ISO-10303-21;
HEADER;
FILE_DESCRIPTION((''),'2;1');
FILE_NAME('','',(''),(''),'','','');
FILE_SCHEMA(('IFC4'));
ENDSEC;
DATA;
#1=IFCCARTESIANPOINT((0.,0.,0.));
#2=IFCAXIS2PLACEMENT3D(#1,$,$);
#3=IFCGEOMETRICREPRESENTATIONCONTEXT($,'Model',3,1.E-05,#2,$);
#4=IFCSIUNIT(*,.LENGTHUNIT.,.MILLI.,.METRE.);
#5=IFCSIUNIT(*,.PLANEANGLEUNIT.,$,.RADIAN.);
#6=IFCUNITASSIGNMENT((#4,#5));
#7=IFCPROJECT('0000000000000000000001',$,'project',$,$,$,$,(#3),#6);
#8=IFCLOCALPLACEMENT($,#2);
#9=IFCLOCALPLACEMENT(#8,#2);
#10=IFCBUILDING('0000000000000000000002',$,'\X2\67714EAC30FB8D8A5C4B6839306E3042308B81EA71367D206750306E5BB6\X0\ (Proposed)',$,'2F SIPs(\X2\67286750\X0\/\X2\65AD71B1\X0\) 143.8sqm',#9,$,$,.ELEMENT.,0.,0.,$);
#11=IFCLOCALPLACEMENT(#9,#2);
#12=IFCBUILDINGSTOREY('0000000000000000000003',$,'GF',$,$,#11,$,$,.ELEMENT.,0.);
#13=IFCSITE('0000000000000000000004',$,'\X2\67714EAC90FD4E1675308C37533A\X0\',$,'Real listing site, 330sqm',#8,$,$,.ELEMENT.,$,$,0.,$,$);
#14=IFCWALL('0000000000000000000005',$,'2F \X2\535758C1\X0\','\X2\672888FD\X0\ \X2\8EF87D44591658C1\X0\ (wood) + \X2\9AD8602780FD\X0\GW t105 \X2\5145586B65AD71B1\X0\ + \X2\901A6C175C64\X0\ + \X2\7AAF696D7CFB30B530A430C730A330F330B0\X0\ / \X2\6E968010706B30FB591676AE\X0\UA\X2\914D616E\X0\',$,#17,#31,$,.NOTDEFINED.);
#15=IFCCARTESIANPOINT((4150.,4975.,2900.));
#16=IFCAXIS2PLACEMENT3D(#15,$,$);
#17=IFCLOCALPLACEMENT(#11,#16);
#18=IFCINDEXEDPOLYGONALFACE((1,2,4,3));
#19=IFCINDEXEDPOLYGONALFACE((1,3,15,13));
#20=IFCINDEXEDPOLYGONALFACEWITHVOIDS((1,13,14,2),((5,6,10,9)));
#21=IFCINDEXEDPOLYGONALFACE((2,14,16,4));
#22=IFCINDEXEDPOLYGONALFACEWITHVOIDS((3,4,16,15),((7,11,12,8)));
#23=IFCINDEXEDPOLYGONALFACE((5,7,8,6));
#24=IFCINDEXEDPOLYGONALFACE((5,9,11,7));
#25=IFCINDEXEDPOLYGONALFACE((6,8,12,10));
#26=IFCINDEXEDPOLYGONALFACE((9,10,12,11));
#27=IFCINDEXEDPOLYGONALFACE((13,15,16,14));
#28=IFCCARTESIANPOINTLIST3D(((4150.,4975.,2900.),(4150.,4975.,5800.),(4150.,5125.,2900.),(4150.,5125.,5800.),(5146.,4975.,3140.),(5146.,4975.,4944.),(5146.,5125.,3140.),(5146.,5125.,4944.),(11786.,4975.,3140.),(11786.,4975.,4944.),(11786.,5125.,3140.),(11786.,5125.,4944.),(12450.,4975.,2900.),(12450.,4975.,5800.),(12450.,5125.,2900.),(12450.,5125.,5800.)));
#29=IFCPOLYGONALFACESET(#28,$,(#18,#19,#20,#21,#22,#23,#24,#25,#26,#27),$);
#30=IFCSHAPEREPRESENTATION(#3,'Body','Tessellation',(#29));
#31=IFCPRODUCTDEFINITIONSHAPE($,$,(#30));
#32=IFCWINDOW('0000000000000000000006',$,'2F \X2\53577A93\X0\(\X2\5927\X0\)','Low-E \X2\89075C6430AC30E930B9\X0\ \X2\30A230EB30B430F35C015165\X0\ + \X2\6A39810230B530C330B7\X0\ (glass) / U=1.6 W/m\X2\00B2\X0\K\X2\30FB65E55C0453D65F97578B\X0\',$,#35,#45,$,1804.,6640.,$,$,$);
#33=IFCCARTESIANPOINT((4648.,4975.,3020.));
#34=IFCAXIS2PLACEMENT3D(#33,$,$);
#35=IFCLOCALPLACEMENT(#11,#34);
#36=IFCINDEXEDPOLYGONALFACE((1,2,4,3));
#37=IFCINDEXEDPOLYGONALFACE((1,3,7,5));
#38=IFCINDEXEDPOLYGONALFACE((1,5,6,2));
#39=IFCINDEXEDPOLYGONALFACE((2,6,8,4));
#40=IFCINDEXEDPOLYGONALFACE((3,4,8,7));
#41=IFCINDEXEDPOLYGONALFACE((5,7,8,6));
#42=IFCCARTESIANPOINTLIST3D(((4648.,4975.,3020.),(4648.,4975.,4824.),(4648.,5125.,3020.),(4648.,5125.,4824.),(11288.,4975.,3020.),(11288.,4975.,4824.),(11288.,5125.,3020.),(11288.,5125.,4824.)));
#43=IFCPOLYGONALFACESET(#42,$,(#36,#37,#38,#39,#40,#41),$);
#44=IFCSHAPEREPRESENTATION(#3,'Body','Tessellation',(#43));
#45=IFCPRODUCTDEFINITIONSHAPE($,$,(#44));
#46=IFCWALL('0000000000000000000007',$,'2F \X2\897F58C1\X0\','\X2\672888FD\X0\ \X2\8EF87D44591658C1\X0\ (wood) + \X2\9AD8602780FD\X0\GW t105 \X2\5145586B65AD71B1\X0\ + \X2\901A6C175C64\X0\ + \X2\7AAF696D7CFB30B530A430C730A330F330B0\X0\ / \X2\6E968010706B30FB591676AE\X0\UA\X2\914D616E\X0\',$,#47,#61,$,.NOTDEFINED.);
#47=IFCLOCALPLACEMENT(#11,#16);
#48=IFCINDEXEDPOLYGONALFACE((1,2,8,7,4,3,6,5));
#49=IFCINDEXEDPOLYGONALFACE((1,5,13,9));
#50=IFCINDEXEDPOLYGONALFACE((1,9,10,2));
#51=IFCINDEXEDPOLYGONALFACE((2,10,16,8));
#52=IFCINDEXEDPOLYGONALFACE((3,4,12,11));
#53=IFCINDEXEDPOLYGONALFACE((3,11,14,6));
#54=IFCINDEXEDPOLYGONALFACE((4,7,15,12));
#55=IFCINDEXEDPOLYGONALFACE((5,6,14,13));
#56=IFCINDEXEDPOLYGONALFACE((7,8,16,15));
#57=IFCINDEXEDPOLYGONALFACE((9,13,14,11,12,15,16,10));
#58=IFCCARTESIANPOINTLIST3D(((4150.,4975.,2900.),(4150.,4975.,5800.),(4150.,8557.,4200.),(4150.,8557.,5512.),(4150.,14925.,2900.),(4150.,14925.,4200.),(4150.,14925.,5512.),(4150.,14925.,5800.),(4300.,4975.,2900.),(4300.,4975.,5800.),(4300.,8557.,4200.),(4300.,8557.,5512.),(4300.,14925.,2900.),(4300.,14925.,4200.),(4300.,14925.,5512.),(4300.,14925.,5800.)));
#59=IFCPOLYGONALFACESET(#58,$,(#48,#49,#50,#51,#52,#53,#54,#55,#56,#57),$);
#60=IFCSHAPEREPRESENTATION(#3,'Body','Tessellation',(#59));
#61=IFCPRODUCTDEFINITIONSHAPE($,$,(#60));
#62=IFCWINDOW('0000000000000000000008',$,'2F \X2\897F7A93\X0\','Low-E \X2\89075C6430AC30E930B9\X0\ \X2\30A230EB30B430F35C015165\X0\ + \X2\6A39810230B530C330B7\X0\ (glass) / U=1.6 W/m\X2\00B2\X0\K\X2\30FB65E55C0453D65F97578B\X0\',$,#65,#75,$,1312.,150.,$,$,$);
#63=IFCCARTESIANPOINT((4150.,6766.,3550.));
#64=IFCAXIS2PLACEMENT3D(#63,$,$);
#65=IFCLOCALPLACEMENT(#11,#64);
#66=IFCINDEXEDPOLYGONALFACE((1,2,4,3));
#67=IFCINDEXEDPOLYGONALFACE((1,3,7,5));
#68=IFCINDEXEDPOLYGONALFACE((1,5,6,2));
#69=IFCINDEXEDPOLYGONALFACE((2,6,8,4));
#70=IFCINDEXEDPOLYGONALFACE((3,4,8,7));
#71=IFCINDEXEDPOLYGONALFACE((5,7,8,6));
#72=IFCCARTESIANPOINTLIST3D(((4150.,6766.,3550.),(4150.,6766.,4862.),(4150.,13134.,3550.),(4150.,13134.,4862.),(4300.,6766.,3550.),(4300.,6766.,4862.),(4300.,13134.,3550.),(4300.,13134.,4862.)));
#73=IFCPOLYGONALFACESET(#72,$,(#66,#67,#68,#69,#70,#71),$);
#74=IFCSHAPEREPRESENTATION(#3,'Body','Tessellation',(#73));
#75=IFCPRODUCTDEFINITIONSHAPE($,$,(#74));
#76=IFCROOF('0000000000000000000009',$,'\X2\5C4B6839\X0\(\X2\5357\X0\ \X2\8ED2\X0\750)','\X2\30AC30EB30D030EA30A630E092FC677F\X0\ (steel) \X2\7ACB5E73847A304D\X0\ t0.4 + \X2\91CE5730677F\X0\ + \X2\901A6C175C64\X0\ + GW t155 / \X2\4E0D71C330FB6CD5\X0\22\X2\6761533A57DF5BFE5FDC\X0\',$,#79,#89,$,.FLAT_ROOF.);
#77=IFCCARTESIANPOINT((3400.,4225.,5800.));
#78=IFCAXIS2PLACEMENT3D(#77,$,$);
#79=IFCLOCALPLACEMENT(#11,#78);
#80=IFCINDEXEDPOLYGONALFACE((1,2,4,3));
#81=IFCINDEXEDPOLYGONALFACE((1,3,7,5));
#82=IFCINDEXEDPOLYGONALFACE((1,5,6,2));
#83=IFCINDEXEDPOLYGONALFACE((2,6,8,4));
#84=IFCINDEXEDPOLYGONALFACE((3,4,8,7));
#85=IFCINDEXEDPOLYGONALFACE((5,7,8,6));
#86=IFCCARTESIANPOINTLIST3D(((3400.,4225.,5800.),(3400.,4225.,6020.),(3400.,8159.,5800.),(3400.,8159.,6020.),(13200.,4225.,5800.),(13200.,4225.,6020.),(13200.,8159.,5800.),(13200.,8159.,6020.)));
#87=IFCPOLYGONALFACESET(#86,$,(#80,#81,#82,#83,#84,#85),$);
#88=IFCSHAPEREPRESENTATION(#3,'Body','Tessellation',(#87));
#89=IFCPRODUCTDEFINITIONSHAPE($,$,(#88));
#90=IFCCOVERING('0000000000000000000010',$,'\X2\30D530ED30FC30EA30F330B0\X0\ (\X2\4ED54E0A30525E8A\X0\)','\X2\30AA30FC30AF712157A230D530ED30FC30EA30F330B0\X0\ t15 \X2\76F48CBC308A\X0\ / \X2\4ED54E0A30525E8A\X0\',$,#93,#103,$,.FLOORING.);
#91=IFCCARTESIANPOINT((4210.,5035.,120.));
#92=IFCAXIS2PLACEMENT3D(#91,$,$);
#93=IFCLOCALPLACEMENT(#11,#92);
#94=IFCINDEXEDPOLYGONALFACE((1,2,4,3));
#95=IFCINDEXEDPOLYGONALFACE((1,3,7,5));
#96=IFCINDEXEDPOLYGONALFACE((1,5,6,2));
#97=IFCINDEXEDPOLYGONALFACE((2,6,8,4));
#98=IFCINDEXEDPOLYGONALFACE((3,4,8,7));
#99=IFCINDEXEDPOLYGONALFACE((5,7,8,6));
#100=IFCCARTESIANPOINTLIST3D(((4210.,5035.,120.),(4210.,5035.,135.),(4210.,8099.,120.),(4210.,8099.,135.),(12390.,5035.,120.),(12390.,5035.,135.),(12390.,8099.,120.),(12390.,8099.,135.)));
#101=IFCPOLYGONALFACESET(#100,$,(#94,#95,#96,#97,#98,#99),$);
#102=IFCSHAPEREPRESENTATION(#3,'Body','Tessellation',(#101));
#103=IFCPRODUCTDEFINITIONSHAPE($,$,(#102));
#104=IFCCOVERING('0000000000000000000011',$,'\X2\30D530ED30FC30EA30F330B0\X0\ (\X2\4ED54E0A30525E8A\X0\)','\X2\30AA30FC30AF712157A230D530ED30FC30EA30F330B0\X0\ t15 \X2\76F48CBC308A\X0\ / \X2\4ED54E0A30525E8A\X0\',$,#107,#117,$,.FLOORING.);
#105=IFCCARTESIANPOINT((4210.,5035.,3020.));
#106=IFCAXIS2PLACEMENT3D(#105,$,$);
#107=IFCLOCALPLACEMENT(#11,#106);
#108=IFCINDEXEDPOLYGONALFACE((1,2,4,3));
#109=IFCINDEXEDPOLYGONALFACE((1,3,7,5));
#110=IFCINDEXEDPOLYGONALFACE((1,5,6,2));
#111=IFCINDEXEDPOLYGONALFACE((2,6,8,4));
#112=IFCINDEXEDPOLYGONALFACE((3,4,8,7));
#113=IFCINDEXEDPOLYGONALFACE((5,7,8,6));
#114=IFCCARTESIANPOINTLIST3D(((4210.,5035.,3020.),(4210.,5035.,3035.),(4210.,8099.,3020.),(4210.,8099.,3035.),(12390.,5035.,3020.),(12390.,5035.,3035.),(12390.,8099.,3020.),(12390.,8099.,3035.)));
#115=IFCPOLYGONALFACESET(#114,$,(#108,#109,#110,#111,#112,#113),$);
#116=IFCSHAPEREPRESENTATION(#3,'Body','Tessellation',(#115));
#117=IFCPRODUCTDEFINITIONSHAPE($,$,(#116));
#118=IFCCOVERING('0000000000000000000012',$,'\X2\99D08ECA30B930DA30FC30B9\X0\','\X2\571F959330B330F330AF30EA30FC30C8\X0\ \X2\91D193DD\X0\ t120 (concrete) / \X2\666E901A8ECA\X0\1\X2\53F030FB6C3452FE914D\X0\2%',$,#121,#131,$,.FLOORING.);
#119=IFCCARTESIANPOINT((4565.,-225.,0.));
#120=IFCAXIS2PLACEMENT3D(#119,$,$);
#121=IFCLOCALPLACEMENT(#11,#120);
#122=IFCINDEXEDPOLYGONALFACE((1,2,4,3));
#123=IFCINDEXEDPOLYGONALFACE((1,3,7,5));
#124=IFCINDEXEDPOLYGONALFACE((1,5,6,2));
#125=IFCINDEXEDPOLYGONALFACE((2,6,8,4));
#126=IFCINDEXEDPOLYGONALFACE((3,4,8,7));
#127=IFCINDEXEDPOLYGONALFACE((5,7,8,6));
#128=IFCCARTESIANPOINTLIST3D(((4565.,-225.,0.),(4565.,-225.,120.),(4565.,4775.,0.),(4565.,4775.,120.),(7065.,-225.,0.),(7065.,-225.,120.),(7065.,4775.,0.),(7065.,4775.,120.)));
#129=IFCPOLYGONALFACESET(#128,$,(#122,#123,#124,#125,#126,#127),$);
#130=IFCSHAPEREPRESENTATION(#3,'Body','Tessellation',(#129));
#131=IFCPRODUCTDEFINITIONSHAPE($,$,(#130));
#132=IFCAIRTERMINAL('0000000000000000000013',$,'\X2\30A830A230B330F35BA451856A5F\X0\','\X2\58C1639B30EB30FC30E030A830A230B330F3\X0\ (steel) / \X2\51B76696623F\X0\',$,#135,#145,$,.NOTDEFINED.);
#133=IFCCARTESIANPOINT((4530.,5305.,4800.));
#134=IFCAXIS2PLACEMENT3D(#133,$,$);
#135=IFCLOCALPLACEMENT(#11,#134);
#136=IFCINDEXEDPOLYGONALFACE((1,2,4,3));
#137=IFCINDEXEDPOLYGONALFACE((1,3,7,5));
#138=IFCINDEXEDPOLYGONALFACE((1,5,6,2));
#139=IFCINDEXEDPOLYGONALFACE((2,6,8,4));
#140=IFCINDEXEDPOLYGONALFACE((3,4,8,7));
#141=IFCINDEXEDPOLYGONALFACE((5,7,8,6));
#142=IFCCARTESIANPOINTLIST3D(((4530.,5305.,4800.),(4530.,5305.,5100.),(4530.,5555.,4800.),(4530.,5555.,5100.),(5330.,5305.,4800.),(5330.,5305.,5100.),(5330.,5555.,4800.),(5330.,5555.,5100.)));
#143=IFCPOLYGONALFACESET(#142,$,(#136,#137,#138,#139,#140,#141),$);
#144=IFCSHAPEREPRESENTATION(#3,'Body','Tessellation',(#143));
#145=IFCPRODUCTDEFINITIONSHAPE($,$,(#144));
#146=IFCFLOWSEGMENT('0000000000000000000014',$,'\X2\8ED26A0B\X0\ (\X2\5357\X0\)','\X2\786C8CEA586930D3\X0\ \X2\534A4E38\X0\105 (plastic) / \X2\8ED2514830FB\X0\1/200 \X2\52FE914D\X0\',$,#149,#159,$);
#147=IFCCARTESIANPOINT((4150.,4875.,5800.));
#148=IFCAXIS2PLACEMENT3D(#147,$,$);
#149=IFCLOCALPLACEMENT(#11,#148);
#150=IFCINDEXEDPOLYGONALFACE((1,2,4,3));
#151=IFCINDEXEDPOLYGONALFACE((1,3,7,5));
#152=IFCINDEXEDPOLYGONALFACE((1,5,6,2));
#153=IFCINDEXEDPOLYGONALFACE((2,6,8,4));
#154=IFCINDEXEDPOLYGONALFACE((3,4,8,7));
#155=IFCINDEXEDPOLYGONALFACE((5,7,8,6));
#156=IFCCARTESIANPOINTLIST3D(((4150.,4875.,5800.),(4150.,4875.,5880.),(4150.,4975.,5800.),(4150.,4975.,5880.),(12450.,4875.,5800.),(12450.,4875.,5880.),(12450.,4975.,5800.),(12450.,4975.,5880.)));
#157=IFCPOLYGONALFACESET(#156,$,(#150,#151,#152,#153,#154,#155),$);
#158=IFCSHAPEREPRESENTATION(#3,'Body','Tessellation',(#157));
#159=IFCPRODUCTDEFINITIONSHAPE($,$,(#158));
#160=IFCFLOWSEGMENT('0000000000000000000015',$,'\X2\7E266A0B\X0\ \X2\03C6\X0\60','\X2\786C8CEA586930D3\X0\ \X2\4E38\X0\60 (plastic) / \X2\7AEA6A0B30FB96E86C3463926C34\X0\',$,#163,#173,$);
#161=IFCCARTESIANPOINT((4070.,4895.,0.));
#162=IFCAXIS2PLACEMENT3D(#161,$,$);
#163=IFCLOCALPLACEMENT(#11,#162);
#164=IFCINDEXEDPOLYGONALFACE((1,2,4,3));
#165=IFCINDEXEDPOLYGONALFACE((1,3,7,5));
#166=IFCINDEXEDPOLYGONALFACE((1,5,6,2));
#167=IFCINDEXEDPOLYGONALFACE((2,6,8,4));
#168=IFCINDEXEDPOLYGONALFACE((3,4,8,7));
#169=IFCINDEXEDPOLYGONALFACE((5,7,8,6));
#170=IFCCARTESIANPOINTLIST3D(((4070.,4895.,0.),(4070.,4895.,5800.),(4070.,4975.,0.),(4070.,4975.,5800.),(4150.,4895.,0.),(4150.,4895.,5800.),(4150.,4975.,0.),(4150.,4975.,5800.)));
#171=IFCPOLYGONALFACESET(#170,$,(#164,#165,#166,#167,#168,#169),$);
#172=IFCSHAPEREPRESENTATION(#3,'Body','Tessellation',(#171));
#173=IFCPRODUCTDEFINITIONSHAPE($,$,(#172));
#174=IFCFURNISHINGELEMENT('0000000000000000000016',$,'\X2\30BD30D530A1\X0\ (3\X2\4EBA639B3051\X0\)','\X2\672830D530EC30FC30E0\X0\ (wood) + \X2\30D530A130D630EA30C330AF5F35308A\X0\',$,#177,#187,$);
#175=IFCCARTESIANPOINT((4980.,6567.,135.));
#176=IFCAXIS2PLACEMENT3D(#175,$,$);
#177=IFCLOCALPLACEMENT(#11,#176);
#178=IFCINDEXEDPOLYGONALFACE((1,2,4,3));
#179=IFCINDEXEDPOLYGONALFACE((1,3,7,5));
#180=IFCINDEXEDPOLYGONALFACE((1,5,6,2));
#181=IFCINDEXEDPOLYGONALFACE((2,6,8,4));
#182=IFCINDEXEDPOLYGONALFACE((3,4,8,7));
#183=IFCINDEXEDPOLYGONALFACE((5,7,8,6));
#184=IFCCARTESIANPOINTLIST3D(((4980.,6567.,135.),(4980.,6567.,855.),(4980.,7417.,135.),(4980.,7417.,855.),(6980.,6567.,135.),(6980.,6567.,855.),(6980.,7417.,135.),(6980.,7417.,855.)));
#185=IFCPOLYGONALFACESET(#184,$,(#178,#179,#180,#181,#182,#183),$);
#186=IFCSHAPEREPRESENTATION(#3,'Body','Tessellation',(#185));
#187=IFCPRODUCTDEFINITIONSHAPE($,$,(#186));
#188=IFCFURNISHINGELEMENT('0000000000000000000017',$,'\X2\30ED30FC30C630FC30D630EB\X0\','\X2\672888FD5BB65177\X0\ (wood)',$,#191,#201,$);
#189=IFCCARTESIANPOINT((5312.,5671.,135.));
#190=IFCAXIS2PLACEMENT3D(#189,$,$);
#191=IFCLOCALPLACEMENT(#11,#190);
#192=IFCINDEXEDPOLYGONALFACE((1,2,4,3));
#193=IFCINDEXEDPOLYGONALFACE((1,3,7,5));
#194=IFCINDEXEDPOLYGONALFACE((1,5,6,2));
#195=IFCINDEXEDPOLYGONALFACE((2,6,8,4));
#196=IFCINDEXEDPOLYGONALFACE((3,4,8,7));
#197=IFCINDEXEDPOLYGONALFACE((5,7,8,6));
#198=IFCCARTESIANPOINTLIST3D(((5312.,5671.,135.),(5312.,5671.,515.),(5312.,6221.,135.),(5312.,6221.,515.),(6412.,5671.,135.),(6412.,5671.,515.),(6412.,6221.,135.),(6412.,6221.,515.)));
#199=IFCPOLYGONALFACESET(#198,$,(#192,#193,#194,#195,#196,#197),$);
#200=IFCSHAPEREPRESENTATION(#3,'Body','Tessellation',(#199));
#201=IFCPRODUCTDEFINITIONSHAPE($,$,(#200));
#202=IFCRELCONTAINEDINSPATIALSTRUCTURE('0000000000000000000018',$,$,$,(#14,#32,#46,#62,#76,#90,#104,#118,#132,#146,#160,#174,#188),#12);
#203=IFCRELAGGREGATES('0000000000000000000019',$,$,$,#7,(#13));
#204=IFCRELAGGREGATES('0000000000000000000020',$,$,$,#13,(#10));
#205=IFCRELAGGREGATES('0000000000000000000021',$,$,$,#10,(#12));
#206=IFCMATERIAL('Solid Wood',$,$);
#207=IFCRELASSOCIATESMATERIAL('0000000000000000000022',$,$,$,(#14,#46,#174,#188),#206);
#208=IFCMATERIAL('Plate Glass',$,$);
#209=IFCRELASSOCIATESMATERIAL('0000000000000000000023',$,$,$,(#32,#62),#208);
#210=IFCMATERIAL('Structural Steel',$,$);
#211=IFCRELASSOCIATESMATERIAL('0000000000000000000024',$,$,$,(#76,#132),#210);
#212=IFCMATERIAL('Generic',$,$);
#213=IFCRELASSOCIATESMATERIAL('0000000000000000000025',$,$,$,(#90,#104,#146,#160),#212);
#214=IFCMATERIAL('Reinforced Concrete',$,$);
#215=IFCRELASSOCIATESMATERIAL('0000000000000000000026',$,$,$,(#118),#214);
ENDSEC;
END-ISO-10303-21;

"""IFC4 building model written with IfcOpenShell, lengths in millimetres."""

from ifc_helpers import new_model, si_unit, frame, frame_2d, origin, place, context, project, spatial, rectangle, extrude, material, element, fill, save


model = new_model("IFC4")

# Units and contexts
model_context = context("Model", 3, precision=1e-05, world=origin())
ifc_project = project(units=[si_unit("LENGTHUNIT", "METRE", prefix="MILLI"), si_unit("PLANEANGLEUNIT", "RADIAN")], contexts=[model_context])

# Site, building, storey
site_placement = place(None, origin())
site = spatial("IfcSite", under=ifc_project, at=site_placement, Name="東京都世田谷区", ObjectType="Real listing site, 330sqm", CompositionType="ELEMENT", RefElevation=0.0)
building_placement = place(site_placement, origin())
building = spatial("IfcBuilding", under=site, at=building_placement, Name="東京・越屋根のある自然素材の家 (Proposed)", ObjectType="2F SIPs(木材/断熱) 143.8sqm", CompositionType="ELEMENT", ElevationOfRefHeight=0.0, ElevationOfTerrain=0.0)
storey_placement = place(building_placement, origin())
storey = spatial("IfcBuildingStorey", under=building, at=storey_placement, Name="GF", CompositionType="ELEMENT", Elevation=0.0)

# Shared definitions
ifc_material_1 = material(Name="Solid Wood")

# Shared definitions
ifc_material_2 = material(Name="Reinforced Concrete")

# Shared definitions
ifc_material_3 = material(Name="Plate Glass")

# Walls, openings, windows
wall_1_placement = place(storey_placement, frame((4150.0, 4975.0, 2900.0)))
wall_1 = element("IfcWall", 1, at=wall_1_placement, inside=storey, material=ifc_material_1, Name="2F 南壁", Description="木製 軸組外壁 (wood) + 高性能GW t105 充填断熱 + 通気層 + 窯業系サイディング / 準耐火・外皮UA配慮", PredefinedType="NOTDEFINED", context=model_context, shape_type="SweptSolid", body=[
    extrude(rectangle(XDim=8300.0, YDim=150.0, at=frame_2d((4150.0, 75.0))), frame((4150.0, 4975.0, 2900.0)), (0.0, 0.0, 1.0), 2900.0),
])
opening_1_placement = place(storey_placement, frame((4648.0, 4975.0, 3020.0)))
opening_1 = element("IfcOpeningElement", 2, at=opening_1_placement, cuts=wall_1, PredefinedType="NOTDEFINED", context=model_context, shape_type="SweptSolid", body=[
    extrude(rectangle(XDim=6640.0, YDim=150.0, at=frame_2d((3320.0, 75.0))), frame((4648.0, 4975.0, 3020.0)), (0.0, 0.0, 1.0), 1804.0),
])
window_1_placement = place(storey_placement, frame((4648.0, 4975.0, 3020.0)))
window_1 = element("IfcWindow", 3, at=window_1_placement, inside=storey, material=ifc_material_3, Name="2F 南窓(大)", Description="Low-E 複層ガラス アルゴン封入 + 樹脂サッシ (glass) / U=1.6 W/m²K・日射取得型", OverallHeight=1804.0, OverallWidth=6640.0, context=model_context, shape_type="SweptSolid", body=[
    extrude(rectangle(XDim=6640.0, YDim=150.0, at=frame_2d((3320.0, 75.0))), frame((4648.0, 4975.0, 3020.0)), (0.0, 0.0, 1.0), 1804.0),
])
fill(opening_1, window_1)
wall_2_placement = place(storey_placement, frame((4150.0, 4975.0, 2900.0)))
wall_2 = element("IfcWall", 4, at=wall_2_placement, inside=storey, material=ifc_material_1, Name="2F 西壁", Description="木製 軸組外壁 (wood) + 高性能GW t105 充填断熱 + 通気層 + 窯業系サイディング / 準耐火・外皮UA配慮", PredefinedType="NOTDEFINED", context=model_context, shape_type="SweptSolid", body=[
    extrude(rectangle(XDim=150.0, YDim=9950.0, at=frame_2d((75.0, 4975.0))), frame((4150.0, 4975.0, 2900.0)), (0.0, 0.0, 1.0), 2900.0),
])
opening_2_placement = place(storey_placement, frame((4150.0, 6766.0, 3550.0)))
opening_2 = element("IfcOpeningElement", 5, at=opening_2_placement, cuts=wall_2, PredefinedType="NOTDEFINED", context=model_context, shape_type="SweptSolid", body=[
    extrude(rectangle(XDim=150.0, YDim=6368.0, at=frame_2d((75.0, 3184.0))), frame((4150.0, 6766.0, 3550.0)), (0.0, 0.0, 1.0), 1312.0),
])
window_2_placement = place(storey_placement, frame((4150.0, 6766.0, 3550.0)))
window_2 = element("IfcWindow", 6, at=window_2_placement, inside=storey, material=ifc_material_3, Name="2F 西窓", Description="Low-E 複層ガラス アルゴン封入 + 樹脂サッシ (glass) / U=1.6 W/m²K・日射取得型", OverallHeight=1312.0, OverallWidth=150.0, context=model_context, shape_type="SweptSolid", body=[
    extrude(rectangle(XDim=150.0, YDim=6368.0, at=frame_2d((75.0, 3184.0))), frame((4150.0, 6766.0, 3550.0)), (0.0, 0.0, 1.0), 1312.0),
])
fill(opening_2, window_2)

# Roof
ifc_material_4 = material(Name="Structural Steel")
for number, where, name in (
    (7, (3400.0, 4225.0, 5800.0), "屋根(南 軒750)"),
):
    element("IfcRoof", number, at=place(storey_placement, frame(where)), inside=storey, material=ifc_material_4, Name=name, Description="ガルバリウム鋼板 (steel) 立平葺き t0.4 + 野地板 + 通気層 + GW t155 / 不燃・法22条区域対応", PredefinedType="FLAT_ROOF", context=model_context, shape_type="SweptSolid", body=[
        extrude(rectangle(XDim=9800.0, YDim=3934.0, at=frame_2d((4900.0, 1967.0))), frame((3400.0, 4225.0, 5800.0)), (0.0, 0.0, 1.0), 220.0),
    ])

# Coverings
ifc_material_5 = material(Name="Generic")
covering_1_placement = place(storey_placement, frame((4210.0, 5035.0, 120.0)))
element("IfcCovering", 8, at=covering_1_placement, inside=storey, material=ifc_material_5, Name="フローリング (仕上げ床)", Description="オーク無垢フローリング t15 直貼り / 仕上げ床", PredefinedType="FLOORING", context=model_context, shape_type="SweptSolid", body=[
    extrude(rectangle(XDim=8180.0, YDim=3064.0, at=frame_2d((4090.0, 1532.0))), frame((4210.0, 5035.0, 120.0)), (0.0, 0.0, 1.0), 15.0),
])
covering_2_placement = place(storey_placement, frame((4210.0, 5035.0, 3020.0)))
element("IfcCovering", 9, at=covering_2_placement, inside=storey, material=ifc_material_5, Name="フローリング (仕上げ床)", Description="オーク無垢フローリング t15 直貼り / 仕上げ床", PredefinedType="FLOORING", context=model_context, shape_type="SweptSolid", body=[
    extrude(rectangle(XDim=8180.0, YDim=3064.0, at=frame_2d((4090.0, 1532.0))), frame((4210.0, 5035.0, 3020.0)), (0.0, 0.0, 1.0), 15.0),
])
covering_3_placement = place(storey_placement, frame((4565.0, -225.0, 0.0)))
element("IfcCovering", 10, at=covering_3_placement, inside=storey, material=ifc_material_2, Name="駐車スペース", Description="土間コンクリート 金鏝 t120 (concrete) / 普通車1台・水勾配2%", PredefinedType="FLOORING", context=model_context, shape_type="SweptSolid", body=[
    extrude(rectangle(XDim=2500.0, YDim=5000.0, at=frame_2d((1250.0, 2500.0))), frame((4565.0, -225.0, 0.0)), (0.0, 0.0, 1.0), 120.0),
])

# Air terminal
air_terminal_placement = place(storey_placement, frame((4530.0, 5305.0, 4800.0)))
element("IfcAirTerminal", 11, at=air_terminal_placement, inside=storey, material=ifc_material_4, Name="エアコン室内機", Description="壁掛ルームエアコン (steel) / 冷暖房", PredefinedType="NOTDEFINED", context=model_context, shape_type="SweptSolid", body=[
    extrude(rectangle(XDim=800.0, YDim=250.0, at=frame_2d((400.0, 125.0))), frame((4530.0, 5305.0, 4800.0)), (0.0, 0.0, 1.0), 300.0),
])

# Flow segments
flow_segment_1_placement = place(storey_placement, frame((4150.0, 4875.0, 5800.0)))
element("IfcFlowSegment", 12, at=flow_segment_1_placement, inside=storey, material=ifc_material_5, Name="軒樋 (南)", Description="硬質塩ビ 半丸105 (plastic) / 軒先・1/200 勾配", context=model_context, shape_type="SweptSolid", body=[
    extrude(rectangle(XDim=8300.0, YDim=100.0, at=frame_2d((4150.0, 50.0))), frame((4150.0, 4875.0, 5800.0)), (0.0, 0.0, 1.0), 80.0),
])
flow_segment_2_placement = place(storey_placement, frame((4070.0, 4895.0, 0.0)))
element("IfcFlowSegment", 13, at=flow_segment_2_placement, inside=storey, material=ifc_material_5, Name="縦樋 φ60", Description="硬質塩ビ 丸60 (plastic) / 竪樋・雨水排水", context=model_context, shape_type="SweptSolid", body=[
    extrude(rectangle(XDim=80.0, YDim=80.0, at=frame_2d((40.0, 40.0))), frame((4070.0, 4895.0, 0.0)), (0.0, 0.0, 1.0), 5800.0),
])

# Furnishing elements
furnishing_1_placement = place(storey_placement, frame((4980.0, 6567.0, 135.0)))
element("IfcFurnishingElement", 14, at=furnishing_1_placement, inside=storey, material=ifc_material_1, Name="ソファ (3人掛け)", Description="木フレーム (wood) + ファブリック張り", context=model_context, shape_type="SweptSolid", body=[
    extrude(rectangle(XDim=2000.0, YDim=850.0, at=frame_2d((1000.0, 425.0))), frame((4980.0, 6567.0, 135.0)), (0.0, 0.0, 1.0), 720.0),
])
furnishing_2_placement = place(storey_placement, frame((5312.0, 5671.0, 135.0)))
element("IfcFurnishingElement", 15, at=furnishing_2_placement, inside=storey, material=ifc_material_1, Name="ローテーブル", Description="木製家具 (wood)", context=model_context, shape_type="SweptSolid", body=[
    extrude(rectangle(XDim=1100.0, YDim=550.0, at=frame_2d((550.0, 275.0))), frame((5312.0, 5671.0, 135.0)), (0.0, 0.0, 1.0), 380.0),
])

save(model, "model.ifc")
